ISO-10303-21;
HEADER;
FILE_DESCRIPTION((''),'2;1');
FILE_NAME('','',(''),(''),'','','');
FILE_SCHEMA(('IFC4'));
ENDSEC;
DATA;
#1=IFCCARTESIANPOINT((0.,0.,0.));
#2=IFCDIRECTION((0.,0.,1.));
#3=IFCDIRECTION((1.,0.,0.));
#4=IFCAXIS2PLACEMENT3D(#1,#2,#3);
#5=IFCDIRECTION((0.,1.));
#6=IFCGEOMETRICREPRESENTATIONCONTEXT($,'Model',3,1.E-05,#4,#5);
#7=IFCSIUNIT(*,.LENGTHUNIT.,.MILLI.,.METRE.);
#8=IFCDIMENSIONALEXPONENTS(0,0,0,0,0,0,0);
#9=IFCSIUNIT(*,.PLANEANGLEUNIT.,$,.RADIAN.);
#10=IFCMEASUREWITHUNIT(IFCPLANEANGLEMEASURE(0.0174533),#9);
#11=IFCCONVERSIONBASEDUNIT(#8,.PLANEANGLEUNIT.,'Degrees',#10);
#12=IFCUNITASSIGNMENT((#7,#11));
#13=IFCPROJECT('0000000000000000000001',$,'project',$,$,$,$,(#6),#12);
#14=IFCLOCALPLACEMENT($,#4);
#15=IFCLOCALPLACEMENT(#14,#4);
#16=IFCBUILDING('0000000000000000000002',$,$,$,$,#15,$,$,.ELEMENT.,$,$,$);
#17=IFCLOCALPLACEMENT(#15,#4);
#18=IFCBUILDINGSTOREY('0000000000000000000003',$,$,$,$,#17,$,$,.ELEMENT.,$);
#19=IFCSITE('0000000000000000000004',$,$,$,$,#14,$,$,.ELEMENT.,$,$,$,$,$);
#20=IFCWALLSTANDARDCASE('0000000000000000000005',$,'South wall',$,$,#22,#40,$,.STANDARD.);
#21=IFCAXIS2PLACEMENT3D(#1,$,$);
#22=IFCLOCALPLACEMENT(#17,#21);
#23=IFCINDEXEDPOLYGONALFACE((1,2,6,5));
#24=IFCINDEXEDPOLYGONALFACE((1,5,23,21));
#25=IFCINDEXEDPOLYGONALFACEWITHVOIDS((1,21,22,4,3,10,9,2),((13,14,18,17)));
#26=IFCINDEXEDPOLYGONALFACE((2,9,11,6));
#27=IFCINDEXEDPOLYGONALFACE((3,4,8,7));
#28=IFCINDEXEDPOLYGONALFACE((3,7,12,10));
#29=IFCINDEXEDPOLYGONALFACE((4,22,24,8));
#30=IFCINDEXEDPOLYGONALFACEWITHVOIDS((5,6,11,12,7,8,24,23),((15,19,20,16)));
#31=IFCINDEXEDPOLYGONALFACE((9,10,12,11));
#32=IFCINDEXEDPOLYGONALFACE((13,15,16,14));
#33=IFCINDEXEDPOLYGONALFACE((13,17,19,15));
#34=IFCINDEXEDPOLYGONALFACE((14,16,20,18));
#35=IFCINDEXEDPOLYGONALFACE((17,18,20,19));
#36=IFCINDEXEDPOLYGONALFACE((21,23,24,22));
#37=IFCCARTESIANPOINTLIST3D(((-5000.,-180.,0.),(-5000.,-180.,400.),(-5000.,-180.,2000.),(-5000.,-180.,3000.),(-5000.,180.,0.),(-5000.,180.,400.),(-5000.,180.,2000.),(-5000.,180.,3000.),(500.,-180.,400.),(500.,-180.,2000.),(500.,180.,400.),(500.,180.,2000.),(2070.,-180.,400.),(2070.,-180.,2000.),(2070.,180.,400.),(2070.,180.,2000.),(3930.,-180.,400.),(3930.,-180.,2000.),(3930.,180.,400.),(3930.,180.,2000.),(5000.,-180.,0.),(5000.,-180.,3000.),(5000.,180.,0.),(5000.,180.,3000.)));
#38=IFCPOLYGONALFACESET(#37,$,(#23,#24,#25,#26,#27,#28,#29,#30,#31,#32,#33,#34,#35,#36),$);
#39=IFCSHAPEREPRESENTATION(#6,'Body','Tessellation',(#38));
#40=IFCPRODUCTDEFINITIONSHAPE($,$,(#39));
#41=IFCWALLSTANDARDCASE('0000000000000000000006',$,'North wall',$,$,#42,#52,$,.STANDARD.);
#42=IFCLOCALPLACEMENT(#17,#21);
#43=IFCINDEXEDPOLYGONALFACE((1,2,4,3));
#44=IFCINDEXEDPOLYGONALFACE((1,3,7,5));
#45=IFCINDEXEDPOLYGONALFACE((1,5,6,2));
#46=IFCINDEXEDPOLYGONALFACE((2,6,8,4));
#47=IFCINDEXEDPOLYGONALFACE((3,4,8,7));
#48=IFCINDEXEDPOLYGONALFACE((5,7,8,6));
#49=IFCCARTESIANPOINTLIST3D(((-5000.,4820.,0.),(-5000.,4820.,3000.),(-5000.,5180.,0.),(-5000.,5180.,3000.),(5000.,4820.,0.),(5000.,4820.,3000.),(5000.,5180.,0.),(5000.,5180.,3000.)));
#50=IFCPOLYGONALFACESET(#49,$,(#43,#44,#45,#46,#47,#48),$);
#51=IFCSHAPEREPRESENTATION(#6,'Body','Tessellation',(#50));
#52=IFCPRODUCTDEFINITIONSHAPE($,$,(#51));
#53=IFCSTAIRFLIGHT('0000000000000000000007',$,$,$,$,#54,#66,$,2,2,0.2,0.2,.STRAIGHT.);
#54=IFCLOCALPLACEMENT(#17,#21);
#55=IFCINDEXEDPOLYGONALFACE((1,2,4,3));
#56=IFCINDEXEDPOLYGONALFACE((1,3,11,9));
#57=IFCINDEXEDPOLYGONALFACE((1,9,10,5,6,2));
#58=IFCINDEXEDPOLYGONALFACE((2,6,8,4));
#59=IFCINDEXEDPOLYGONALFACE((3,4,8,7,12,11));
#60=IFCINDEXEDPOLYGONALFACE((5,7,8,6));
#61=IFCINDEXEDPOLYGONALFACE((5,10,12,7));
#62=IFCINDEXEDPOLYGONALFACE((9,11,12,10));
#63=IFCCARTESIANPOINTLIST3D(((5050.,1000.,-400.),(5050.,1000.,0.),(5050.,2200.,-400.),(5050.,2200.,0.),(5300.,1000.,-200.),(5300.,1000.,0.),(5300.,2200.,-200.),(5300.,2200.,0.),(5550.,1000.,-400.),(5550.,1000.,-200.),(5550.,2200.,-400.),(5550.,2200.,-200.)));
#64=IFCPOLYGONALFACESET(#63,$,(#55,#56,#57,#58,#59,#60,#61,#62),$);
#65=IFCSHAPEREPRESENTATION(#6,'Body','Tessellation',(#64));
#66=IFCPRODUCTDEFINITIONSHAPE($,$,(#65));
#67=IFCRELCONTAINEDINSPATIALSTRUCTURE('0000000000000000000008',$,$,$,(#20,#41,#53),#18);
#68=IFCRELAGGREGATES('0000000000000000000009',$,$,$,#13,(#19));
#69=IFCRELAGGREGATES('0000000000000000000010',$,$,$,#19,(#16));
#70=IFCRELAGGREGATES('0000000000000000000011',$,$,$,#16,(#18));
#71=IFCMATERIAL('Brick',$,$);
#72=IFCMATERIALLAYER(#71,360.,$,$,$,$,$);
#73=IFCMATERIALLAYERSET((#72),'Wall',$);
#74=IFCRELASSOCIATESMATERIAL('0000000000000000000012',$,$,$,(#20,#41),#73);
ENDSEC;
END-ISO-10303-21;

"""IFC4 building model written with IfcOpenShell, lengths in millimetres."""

from ifc_helpers import new_model, entity, si_unit, converted_unit, direction, frame, origin_with_axes, place, context, project, spatial, polyline, outline, extrude, material, layer, layer_set, layer_usage, element, save


model = new_model("IFC4")

# Units and contexts
model_context = context("Model", 3, precision=1e-05, world=origin_with_axes(), true_north=direction((0.0, 1.0)))
ifc_project = project(units=[si_unit("LENGTHUNIT", "METRE", prefix="MILLI"), converted_unit("PLANEANGLEUNIT", "Degrees", entity("IfcPlaneAngleMeasure", 0.0174533), si_unit("PLANEANGLEUNIT", "RADIAN"), dimensions=[0, 0, 0, 0, 0, 0, 0])], contexts=[model_context])

# Site, building, storey
site_placement = place(None, origin_with_axes())
site = spatial("IfcSite", under=ifc_project, at=site_placement, CompositionType="ELEMENT")
building_placement = place(site_placement, origin_with_axes())
building = spatial("IfcBuilding", under=site, at=building_placement, CompositionType="ELEMENT")
storey_placement = place(building_placement, origin_with_axes())
storey = spatial("IfcBuildingStorey", under=building, at=storey_placement, CompositionType="ELEMENT")

# Shared definitions
ifc_material = material(Name="Brick")
ifc_layer = layer(ifc_material, 360.0)
ifc_layer_set = layer_set([ifc_layer], Name="Wall")
ifc_layer_usage = layer_usage(ifc_layer_set, "AXIS2", "POSITIVE", -180.0)

# Wall, openings
wall_1_placement = place(storey_placement, origin_with_axes())
wall_1 = element("IfcWallStandardCase", 1, at=wall_1_placement, inside=storey, material=ifc_layer_usage, Name="South wall", PredefinedType="STANDARD", context=model_context, shape_type="SweptSolid", body=[
    extrude(outline(polyline([(-5000.0, -180.0), (5000.0, -180.0), (5000.0, 180.0), (-5000.0, 180.0), (-5000.0, -180.0), (-5000.0, -180.0)])), origin_with_axes(), (0.0, 0.0, 1.0), 3000.0),
])
opening_1_placement = place(wall_1_placement, frame((-2500.0, 0.0, 400.0), z_axis=(0.0, 0.0, 1.0), x_axis=(1.0, 0.0, 0.0)))
element("IfcOpeningElement", 2, at=opening_1_placement, cuts=wall_1, PredefinedType="OPENING", context=model_context, shape_type="SweptSolid", body=[
    extrude(outline(polyline([(-3000.0, -1815.0), (3000.0, -1815.0), (3000.0, 1815.0), (-3000.0, 1815.0), (-3000.0, -1815.0), (-3000.0, -1815.0)])), origin_with_axes(), (0.0, 0.0, 1.0), 1600.0),
])
opening_2_placement = place(storey_placement, frame((3000.0, 0.0, 400.0), z_axis=(0.0, 0.0, 1.0), x_axis=(1.0, 0.0, 0.0)))
element("IfcOpeningElement", 3, at=opening_2_placement, cuts=wall_1, PredefinedType="OPENING", context=model_context, shape_type="SweptSolid", body=[
    extrude(outline(polyline([(-930.0, -1500.0), (930.0, -1500.0), (930.0, 1500.0), (-930.0, 1500.0), (-930.0, -1500.0), (-930.0, -1500.0)])), origin_with_axes(), (0.0, 0.0, 1.0), 1600.0),
])

# Wall
wall_2_placement = place(storey_placement, frame((0.0, 5000.0, 0.0), z_axis=(0.0, 0.0, 1.0), x_axis=(1.0, 0.0, 0.0)))
element("IfcWallStandardCase", 4, at=wall_2_placement, inside=storey, material=ifc_layer_usage, Name="North wall", PredefinedType="STANDARD", context=model_context, shape_type="SweptSolid", body=[
    extrude(outline(polyline([(-5000.0, -180.0), (5000.0, -180.0), (5000.0, 180.0), (-5000.0, 180.0), (-5000.0, -180.0), (-5000.0, -180.0)])), origin_with_axes(), (0.0, 0.0, 1.0), 3000.0),
])

# Stair flight
stair_flight_placement = place(storey_placement, frame((5050.0, 1000.0, 0.0), z_axis=(0.0, 1.0, 0.0), x_axis=(1.0, 0.0, 0.0)))
element("IfcStairFlight", 5, at=stair_flight_placement, inside=storey, NumberOfRisers=2, NumberOfTreads=2, PredefinedType="STRAIGHT", RiserHeight=0.2, TreadLength=0.2, context=model_context, shape_type="SweptSolid", body=[
    extrude(outline(polyline([(0.0, 0.0), (250.0, 0.0), (250.0, 200.0), (500.0, 200.0), (500.0, 400.0), (0.0, 400.0), (0.0, 0.0)])), origin_with_axes(), (0.0, 0.0, 1.0), 1200.0),
])

save(model, "model.ifc")
